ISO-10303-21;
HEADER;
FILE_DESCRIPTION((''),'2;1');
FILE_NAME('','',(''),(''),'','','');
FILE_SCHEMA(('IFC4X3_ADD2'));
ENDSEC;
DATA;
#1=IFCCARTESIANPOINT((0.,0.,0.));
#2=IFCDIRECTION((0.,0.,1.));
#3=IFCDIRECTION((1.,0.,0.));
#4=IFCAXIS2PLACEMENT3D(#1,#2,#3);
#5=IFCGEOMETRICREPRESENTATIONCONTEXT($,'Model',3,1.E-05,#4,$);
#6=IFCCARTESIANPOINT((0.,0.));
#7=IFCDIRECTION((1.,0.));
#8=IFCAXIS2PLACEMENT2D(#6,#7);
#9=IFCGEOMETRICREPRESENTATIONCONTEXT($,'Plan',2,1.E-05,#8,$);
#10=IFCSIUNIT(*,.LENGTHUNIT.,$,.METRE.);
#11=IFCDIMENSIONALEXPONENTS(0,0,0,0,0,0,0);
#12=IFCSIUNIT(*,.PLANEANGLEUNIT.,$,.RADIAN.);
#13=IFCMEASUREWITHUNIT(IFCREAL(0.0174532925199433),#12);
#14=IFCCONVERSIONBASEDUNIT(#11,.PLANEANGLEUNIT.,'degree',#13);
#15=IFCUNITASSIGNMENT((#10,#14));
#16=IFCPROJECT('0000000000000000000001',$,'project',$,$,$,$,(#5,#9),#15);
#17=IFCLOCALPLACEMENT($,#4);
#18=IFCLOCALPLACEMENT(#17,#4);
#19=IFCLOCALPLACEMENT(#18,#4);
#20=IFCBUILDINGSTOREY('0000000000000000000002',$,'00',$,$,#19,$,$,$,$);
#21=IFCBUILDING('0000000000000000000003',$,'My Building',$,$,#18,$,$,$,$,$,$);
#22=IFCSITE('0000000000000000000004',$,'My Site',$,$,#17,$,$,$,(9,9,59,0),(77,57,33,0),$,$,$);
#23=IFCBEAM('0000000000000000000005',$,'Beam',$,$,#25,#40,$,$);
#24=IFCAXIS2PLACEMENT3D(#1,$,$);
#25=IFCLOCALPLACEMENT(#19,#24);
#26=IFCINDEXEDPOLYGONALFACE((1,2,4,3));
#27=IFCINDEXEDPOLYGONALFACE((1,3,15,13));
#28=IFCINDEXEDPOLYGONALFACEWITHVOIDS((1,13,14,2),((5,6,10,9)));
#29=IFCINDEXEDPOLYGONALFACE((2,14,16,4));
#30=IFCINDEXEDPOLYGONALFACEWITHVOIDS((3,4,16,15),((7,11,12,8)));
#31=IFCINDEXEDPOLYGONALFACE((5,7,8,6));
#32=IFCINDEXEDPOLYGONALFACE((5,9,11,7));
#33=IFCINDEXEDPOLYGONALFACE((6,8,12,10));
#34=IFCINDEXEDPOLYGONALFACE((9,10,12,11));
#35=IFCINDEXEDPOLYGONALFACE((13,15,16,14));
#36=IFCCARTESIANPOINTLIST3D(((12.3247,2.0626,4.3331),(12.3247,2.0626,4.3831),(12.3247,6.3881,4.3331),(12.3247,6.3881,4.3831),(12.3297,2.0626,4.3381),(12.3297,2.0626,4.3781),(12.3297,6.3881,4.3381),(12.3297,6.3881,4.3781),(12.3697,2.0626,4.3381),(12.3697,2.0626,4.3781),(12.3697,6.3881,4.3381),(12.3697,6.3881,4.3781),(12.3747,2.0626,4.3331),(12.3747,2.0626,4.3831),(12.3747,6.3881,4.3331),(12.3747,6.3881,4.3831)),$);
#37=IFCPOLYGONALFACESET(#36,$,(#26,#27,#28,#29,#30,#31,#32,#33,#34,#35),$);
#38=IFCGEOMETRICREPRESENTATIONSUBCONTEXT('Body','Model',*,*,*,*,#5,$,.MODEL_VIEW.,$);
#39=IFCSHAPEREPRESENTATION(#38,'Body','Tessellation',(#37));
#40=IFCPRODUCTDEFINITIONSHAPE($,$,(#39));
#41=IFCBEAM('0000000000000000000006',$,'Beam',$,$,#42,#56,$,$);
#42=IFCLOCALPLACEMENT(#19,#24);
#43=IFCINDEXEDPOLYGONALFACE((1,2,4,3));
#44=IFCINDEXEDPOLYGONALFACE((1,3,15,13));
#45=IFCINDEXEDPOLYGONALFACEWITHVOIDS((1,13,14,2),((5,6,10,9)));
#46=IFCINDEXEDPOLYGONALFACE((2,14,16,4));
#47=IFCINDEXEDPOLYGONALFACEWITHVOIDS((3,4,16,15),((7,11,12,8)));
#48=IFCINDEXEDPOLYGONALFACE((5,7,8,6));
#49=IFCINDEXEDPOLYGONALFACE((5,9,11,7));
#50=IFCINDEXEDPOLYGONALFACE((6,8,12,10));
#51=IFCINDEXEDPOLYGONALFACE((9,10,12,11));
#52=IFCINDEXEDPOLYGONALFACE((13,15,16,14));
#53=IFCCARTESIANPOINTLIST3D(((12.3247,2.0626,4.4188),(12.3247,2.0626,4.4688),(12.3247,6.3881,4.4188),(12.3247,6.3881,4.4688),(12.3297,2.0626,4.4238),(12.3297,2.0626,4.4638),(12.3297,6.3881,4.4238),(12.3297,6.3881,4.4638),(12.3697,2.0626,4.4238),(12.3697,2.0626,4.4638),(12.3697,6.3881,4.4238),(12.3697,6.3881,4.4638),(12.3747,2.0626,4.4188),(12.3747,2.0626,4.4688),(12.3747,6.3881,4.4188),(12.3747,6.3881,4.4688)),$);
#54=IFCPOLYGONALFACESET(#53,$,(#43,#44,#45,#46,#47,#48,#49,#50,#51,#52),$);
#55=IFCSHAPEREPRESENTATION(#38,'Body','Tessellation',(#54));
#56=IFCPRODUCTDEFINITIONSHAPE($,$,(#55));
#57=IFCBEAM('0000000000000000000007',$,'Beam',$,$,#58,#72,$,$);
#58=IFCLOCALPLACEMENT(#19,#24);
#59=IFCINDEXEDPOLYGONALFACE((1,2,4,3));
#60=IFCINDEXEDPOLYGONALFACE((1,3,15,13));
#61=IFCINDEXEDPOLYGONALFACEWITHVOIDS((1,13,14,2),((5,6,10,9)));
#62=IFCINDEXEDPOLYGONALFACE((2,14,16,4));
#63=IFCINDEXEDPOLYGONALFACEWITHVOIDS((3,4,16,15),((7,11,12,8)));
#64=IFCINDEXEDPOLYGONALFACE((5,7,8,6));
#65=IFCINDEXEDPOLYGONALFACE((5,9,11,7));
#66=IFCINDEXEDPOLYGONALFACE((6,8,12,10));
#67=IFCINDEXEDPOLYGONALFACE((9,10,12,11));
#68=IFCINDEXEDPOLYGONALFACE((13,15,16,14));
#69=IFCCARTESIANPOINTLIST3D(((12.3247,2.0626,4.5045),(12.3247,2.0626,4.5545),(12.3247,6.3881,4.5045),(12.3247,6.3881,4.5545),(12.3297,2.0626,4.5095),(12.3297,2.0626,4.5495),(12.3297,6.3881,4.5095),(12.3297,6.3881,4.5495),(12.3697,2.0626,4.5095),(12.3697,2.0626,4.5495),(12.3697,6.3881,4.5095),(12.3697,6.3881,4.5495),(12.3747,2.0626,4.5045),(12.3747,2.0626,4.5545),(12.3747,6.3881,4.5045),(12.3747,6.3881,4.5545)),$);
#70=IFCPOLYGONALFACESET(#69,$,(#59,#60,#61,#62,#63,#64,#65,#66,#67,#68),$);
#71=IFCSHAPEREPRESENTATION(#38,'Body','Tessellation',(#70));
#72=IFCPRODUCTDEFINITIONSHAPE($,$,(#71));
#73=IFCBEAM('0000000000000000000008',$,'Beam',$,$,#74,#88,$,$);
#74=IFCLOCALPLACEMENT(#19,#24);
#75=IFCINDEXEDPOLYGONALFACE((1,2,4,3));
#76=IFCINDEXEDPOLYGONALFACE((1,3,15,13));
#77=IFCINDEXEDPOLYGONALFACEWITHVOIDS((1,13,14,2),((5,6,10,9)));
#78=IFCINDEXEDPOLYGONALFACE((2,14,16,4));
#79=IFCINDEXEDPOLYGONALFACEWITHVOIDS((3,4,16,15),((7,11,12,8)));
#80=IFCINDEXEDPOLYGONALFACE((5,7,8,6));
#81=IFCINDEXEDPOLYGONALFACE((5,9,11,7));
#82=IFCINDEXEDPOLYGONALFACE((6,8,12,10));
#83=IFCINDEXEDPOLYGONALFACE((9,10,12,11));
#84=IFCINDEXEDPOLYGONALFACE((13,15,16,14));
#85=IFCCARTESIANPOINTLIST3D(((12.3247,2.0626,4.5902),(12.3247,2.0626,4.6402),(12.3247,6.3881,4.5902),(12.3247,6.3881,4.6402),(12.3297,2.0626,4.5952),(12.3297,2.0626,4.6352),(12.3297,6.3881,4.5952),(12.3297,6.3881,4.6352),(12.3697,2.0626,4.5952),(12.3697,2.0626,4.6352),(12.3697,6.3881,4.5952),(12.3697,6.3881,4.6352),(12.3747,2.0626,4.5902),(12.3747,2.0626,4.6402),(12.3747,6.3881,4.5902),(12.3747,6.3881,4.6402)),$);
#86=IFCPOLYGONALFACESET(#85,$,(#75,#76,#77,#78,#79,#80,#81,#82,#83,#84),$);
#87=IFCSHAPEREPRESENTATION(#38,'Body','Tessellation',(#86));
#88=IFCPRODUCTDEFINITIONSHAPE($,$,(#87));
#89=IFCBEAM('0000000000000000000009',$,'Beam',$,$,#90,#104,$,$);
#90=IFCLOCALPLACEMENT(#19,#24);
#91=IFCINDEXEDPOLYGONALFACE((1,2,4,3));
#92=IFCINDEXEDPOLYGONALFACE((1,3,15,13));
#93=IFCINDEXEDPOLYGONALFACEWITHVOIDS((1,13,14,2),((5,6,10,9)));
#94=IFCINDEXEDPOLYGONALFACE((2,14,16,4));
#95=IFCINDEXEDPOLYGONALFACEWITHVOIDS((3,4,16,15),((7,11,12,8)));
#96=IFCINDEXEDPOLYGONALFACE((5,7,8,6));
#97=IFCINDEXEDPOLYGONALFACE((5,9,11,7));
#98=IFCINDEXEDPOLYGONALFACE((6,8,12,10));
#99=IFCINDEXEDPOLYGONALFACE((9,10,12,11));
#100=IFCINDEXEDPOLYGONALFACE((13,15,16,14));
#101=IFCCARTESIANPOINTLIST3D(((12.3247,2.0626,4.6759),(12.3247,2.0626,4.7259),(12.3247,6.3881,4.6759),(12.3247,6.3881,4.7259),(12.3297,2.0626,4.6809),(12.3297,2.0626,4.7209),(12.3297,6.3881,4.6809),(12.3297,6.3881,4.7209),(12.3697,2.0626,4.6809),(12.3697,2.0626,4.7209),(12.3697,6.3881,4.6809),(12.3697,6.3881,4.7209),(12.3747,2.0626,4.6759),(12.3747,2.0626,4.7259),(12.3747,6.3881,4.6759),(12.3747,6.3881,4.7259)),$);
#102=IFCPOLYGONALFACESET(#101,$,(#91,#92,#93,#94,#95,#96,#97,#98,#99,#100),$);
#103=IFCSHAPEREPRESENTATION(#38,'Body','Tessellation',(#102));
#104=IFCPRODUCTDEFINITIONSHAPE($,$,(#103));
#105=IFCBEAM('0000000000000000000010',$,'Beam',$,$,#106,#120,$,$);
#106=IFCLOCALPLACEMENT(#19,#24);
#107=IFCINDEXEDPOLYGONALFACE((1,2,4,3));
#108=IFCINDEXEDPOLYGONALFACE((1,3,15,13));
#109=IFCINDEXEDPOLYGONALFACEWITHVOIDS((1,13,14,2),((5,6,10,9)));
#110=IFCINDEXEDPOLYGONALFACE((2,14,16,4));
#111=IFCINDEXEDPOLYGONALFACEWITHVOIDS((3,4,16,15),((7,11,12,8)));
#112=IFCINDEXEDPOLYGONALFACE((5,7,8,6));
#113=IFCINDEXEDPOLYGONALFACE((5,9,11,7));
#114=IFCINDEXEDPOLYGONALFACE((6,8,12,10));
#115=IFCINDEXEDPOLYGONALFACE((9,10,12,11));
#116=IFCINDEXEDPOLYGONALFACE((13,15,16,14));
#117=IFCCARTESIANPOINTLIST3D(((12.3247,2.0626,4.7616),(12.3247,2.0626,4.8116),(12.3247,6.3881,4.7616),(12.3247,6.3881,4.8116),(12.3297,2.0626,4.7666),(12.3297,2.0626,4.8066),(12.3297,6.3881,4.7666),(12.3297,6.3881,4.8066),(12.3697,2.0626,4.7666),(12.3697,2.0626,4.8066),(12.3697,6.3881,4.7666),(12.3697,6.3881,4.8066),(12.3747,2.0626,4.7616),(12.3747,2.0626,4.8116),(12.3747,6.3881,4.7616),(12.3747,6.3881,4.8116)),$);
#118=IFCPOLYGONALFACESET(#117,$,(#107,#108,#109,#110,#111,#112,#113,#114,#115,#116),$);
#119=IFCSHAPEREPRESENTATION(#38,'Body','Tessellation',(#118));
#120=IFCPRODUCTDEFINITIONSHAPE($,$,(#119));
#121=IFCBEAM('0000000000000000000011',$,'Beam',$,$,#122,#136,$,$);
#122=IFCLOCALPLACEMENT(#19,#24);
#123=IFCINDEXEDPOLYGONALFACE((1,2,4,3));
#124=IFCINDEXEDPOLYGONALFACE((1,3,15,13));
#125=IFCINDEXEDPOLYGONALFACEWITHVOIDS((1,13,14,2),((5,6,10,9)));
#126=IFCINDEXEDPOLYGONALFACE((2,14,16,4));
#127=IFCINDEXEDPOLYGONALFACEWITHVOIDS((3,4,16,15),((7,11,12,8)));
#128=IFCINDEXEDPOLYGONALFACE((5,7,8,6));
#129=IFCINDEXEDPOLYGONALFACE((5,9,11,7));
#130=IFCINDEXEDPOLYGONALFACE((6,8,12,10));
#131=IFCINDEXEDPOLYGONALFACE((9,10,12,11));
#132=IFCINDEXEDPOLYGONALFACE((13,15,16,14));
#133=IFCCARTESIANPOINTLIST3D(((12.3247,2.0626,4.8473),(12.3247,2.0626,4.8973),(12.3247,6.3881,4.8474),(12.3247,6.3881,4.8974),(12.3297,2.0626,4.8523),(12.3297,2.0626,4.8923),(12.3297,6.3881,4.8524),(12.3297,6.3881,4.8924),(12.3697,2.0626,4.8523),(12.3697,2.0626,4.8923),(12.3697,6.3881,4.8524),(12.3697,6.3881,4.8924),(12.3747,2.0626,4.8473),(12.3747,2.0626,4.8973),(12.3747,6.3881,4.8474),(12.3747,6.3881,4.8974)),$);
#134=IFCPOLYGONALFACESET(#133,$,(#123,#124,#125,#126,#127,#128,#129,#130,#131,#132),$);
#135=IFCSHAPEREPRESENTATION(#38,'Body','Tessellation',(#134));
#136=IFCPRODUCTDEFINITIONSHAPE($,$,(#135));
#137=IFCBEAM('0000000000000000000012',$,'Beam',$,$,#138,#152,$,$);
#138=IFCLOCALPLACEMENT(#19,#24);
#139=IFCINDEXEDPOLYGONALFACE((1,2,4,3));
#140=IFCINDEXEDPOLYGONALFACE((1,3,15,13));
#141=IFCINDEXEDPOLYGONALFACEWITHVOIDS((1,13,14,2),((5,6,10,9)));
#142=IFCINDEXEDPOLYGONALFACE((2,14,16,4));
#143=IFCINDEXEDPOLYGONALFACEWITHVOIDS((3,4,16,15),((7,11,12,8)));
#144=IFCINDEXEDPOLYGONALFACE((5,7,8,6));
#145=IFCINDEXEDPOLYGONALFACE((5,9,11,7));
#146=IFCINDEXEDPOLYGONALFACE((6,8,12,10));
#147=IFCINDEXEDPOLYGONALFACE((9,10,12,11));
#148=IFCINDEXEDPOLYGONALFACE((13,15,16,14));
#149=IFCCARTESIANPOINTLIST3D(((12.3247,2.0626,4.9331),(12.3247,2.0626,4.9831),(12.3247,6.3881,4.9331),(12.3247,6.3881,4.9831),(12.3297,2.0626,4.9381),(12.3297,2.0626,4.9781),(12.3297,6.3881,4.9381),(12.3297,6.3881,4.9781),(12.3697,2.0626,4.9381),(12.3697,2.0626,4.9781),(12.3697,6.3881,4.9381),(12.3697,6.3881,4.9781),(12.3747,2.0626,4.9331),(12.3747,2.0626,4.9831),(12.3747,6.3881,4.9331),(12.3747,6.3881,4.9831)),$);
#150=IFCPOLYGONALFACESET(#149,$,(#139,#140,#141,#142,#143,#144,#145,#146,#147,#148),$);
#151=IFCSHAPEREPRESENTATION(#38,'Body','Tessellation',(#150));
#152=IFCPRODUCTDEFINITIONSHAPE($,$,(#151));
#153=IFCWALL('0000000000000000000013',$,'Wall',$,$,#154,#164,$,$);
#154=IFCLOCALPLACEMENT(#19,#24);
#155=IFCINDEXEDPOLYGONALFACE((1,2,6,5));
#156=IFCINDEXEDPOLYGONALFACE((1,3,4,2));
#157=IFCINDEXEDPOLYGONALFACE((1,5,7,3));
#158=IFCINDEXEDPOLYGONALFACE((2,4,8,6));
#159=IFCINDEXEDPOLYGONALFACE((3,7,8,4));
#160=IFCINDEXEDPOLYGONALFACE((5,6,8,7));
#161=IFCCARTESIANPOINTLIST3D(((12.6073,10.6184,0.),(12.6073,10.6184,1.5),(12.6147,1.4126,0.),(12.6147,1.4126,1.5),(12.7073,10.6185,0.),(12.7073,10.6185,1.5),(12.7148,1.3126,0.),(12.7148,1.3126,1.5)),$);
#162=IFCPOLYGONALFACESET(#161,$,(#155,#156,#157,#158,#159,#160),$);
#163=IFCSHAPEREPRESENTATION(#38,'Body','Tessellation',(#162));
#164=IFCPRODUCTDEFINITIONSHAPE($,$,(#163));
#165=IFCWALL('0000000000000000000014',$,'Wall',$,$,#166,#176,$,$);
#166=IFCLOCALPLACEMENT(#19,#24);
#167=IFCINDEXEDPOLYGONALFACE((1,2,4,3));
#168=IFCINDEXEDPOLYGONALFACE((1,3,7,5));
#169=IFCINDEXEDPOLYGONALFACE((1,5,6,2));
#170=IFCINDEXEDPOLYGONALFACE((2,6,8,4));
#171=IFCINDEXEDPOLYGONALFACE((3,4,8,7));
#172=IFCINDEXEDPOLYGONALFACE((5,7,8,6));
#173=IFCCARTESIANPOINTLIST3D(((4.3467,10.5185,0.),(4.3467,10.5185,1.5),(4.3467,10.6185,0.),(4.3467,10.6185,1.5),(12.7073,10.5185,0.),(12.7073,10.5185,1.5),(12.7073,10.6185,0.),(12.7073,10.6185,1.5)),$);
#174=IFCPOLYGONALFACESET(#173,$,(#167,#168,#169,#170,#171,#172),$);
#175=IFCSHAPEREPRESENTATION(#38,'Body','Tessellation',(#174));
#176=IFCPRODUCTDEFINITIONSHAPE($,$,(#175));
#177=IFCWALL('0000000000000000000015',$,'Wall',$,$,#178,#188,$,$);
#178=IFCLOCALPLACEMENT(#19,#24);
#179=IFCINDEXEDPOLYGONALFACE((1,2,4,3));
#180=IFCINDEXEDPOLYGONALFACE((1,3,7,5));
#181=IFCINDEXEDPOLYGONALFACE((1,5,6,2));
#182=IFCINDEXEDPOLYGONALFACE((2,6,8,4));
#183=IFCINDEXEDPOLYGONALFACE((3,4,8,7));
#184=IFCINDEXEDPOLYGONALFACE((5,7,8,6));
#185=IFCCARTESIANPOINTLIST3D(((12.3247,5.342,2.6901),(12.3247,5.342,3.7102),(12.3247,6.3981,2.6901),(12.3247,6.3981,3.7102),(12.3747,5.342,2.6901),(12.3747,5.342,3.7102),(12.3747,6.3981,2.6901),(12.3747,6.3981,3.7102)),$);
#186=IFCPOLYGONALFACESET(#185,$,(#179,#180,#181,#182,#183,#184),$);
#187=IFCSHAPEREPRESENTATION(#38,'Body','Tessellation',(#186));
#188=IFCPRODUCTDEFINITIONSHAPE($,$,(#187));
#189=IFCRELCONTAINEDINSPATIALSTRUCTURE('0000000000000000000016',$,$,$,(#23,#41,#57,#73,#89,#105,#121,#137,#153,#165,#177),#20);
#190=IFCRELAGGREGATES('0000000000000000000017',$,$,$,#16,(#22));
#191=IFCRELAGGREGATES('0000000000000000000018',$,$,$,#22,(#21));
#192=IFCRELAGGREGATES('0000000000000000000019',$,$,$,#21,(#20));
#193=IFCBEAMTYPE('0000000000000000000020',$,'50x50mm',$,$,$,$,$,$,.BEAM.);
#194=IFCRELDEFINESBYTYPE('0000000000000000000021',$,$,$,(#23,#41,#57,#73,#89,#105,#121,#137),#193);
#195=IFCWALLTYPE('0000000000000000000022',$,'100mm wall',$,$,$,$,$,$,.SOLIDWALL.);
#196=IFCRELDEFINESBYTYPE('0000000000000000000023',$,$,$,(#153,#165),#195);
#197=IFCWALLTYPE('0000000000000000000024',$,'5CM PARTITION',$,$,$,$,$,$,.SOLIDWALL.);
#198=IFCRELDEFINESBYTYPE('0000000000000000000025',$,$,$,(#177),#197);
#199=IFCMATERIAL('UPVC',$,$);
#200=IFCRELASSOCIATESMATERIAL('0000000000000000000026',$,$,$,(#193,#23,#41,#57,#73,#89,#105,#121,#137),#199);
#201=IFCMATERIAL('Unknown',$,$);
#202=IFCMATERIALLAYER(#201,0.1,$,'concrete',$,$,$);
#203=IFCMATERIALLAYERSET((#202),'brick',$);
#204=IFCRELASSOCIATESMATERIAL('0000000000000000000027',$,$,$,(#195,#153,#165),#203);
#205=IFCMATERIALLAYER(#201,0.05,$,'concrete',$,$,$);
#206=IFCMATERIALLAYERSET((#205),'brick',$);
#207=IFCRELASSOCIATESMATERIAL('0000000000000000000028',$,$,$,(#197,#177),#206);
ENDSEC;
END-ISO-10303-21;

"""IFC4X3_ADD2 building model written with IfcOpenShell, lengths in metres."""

from ifc_helpers import new_model, entity, si_unit, converted_unit, frame, origin_with_axes, origin_2d_with_axis, place, context, subcontext, project, spatial, line, indexed_curve, hollow_rectangle, outline, extrude, material, layer, layer_set, layer_usage, material_profile, profile_set, profile_usage, type_object, element, save


model = new_model("IFC4X3_ADD2")

# Units and contexts
model_context = context("Model", 3, precision=1e-05, world=origin_with_axes())
plan_context = context("Plan", 2, precision=1e-05, world=origin_2d_with_axis())
body_context = subcontext(model_context, "Body", "Model", "MODEL_VIEW")
ifc_project = project(units=[si_unit("LENGTHUNIT", "METRE"), converted_unit("PLANEANGLEUNIT", "degree", entity("IfcReal", 0.0174532925199433), si_unit("PLANEANGLEUNIT", "RADIAN"), dimensions=[0, 0, 0, 0, 0, 0, 0])], contexts=[model_context, plan_context])

# Site, building, storey
site_placement = place(None, origin_with_axes())
site = spatial("IfcSite", under=ifc_project, at=site_placement, Name="My Site", RefLatitude=(9, 9, 59, 0), RefLongitude=(77, 57, 33, 0))
building_placement = place(site_placement, origin_with_axes())
building = spatial("IfcBuilding", under=site, at=building_placement, Name="My Building")
storey_placement = place(building_placement, origin_with_axes())
storey = spatial("IfcBuildingStorey", under=building, at=storey_placement, Name="00")

# Shared definitions
ifc_material_1 = material(Name="UPVC")

# Beams
ifc_material_profile_1 = material_profile(ifc_material_1, hollow_rectangle(XDim=0.05, YDim=0.05, WallThickness=0.005))
ifc_profile_set_1 = profile_set([ifc_material_profile_1])
beam_type = type_object("IfcBeamType", Name="50x50mm", PredefinedType="BEAM", material=ifc_profile_set_1)
ifc_profile_usage_1 = profile_usage(ifc_profile_set_1, cardinal=5)
beam_1_placement = place(storey_placement, frame((12.3497, 2.0626, 4.3581), z_axis=(0.0, 1.0, 0.000001), x_axis=(-1.0, 0.0, 0.0)))
element("IfcBeam", 1, at=beam_1_placement, inside=storey, type_object=beam_type, material=ifc_profile_usage_1, Name="Beam", context=body_context, shape_type="SweptSolid", body=[
    extrude(hollow_rectangle(XDim=0.05, YDim=0.05, WallThickness=0.005), origin_with_axes(), (0.0, 0.0, 1.0), 4.3255),
])
ifc_profile_usage_2 = profile_usage(ifc_profile_set_1, cardinal=5)
beam_2_placement = place(storey_placement, frame((12.3497, 2.0626, 4.4438), z_axis=(0.0, 1.0, 0.000001), x_axis=(-1.0, 0.0, 0.0)))
element("IfcBeam", 2, at=beam_2_placement, inside=storey, type_object=beam_type, material=ifc_profile_usage_2, Name="Beam", context=body_context, shape_type="SweptSolid", body=[
    extrude(hollow_rectangle(XDim=0.05, YDim=0.05, WallThickness=0.005), origin_with_axes(), (0.0, 0.0, 1.0), 4.3255),
])
ifc_profile_usage_3 = profile_usage(ifc_profile_set_1, cardinal=5)
beam_3_placement = place(storey_placement, frame((12.3497, 2.0626, 4.5295), z_axis=(0.0, 1.0, 0.000001), x_axis=(-1.0, 0.0, 0.0)))
element("IfcBeam", 3, at=beam_3_placement, inside=storey, type_object=beam_type, material=ifc_profile_usage_3, Name="Beam", context=body_context, shape_type="SweptSolid", body=[
    extrude(hollow_rectangle(XDim=0.05, YDim=0.05, WallThickness=0.005), origin_with_axes(), (0.0, 0.0, 1.0), 4.3255),
])
ifc_profile_usage_4 = profile_usage(ifc_profile_set_1, cardinal=5)
beam_4_placement = place(storey_placement, frame((12.3497, 2.0626, 4.6152), z_axis=(0.0, 1.0, 0.000001), x_axis=(-1.0, 0.0, 0.0)))
element("IfcBeam", 4, at=beam_4_placement, inside=storey, type_object=beam_type, material=ifc_profile_usage_4, Name="Beam", context=body_context, shape_type="SweptSolid", body=[
    extrude(hollow_rectangle(XDim=0.05, YDim=0.05, WallThickness=0.005), origin_with_axes(), (0.0, 0.0, 1.0), 4.3255),
])
ifc_profile_usage_5 = profile_usage(ifc_profile_set_1, cardinal=5)
beam_5_placement = place(storey_placement, frame((12.3497, 2.0626, 4.7009), z_axis=(0.0, 1.0, 0.000001), x_axis=(-1.0, 0.0, 0.0)))
element("IfcBeam", 5, at=beam_5_placement, inside=storey, type_object=beam_type, material=ifc_profile_usage_5, Name="Beam", context=body_context, shape_type="SweptSolid", body=[
    extrude(hollow_rectangle(XDim=0.05, YDim=0.05, WallThickness=0.005), origin_with_axes(), (0.0, 0.0, 1.0), 4.3255),
])
ifc_profile_usage_6 = profile_usage(ifc_profile_set_1, cardinal=5)
beam_6_placement = place(storey_placement, frame((12.3497, 2.0626, 4.7866), z_axis=(0.0, 1.0, 0.000001), x_axis=(-1.0, 0.0, 0.0)))
element("IfcBeam", 6, at=beam_6_placement, inside=storey, type_object=beam_type, material=ifc_profile_usage_6, Name="Beam", context=body_context, shape_type="SweptSolid", body=[
    extrude(hollow_rectangle(XDim=0.05, YDim=0.05, WallThickness=0.005), origin_with_axes(), (0.0, 0.0, 1.0), 4.3255),
])
ifc_profile_usage_7 = profile_usage(ifc_profile_set_1, cardinal=5)
beam_7_placement = place(storey_placement, frame((12.3497, 2.0626, 4.8723), z_axis=(0.0, 1.0, 0.000001), x_axis=(-1.0, 0.0, 0.0)))
element("IfcBeam", 7, at=beam_7_placement, inside=storey, type_object=beam_type, material=ifc_profile_usage_7, Name="Beam", context=body_context, shape_type="SweptSolid", body=[
    extrude(hollow_rectangle(XDim=0.05, YDim=0.05, WallThickness=0.005), origin_with_axes(), (0.0, 0.0, 1.0), 4.3255),
])
ifc_profile_usage_8 = profile_usage(ifc_profile_set_1, cardinal=5)
beam_8_placement = place(storey_placement, frame((12.3497, 2.0626, 4.9581), z_axis=(0.0, 1.0, 0.000001), x_axis=(-1.0, 0.0, 0.0)))
element("IfcBeam", 8, at=beam_8_placement, inside=storey, type_object=beam_type, material=ifc_profile_usage_8, Name="Beam", context=body_context, shape_type="SweptSolid", body=[
    extrude(hollow_rectangle(XDim=0.05, YDim=0.05, WallThickness=0.005), origin_with_axes(), (0.0, 0.0, 1.0), 4.3255),
])

# Walls
ifc_material_2 = material(Name="Unknown")
ifc_layer_1 = layer(ifc_material_2, 0.1, Name="concrete")
ifc_layer_set_1 = layer_set([ifc_layer_1], Name="brick")
ifc_layer_usage_1 = layer_usage(ifc_layer_set_1, "AXIS2", "POSITIVE", 0.0)
wall_type_1 = type_object("IfcWallType", Name="100mm wall", PredefinedType="SOLIDWALL", material=ifc_layer_set_1)
wall_1_placement = place(storey_placement, frame((12.7148, 1.3126, 0.0), z_axis=(0.0, 0.0, 1.0), x_axis=(-0.000805, 1.0, 0.0)))
element("IfcWall", 9, at=wall_1_placement, inside=storey, type_object=wall_type_1, material=ifc_layer_usage_1, Name="Wall", context=body_context, shape_type="SweptSolid", body=[
    extrude(outline(indexed_curve([(0.0, 0.0), (0.1001, 0.1), (9.3059, 0.1), (9.3059, 0.0)], segments=[line(1, 2, 3, 4, 1)])), origin_with_axes(), (0.0, 0.0, 1.0), 1.5),
])
ifc_layer_usage_2 = layer_usage(ifc_layer_set_1, "AXIS2", "POSITIVE", 0.0)
wall_2_placement = place(storey_placement, frame((12.7073, 10.6185, 0.0), z_axis=(0.0, 0.0, 1.0), x_axis=(-1.0, 0.0, 0.0)))
element("IfcWall", 10, at=wall_2_placement, inside=storey, type_object=wall_type_1, material=ifc_layer_usage_2, Name="Wall", context=body_context, shape_type="SweptSolid", body=[
    extrude(outline(indexed_curve([(0.0, 0.0), (0.0, 0.1), (8.3606, 0.1), (8.3606, 0.0)], segments=[line(1, 2, 3, 4, 1)])), origin_with_axes(), (0.0, 0.0, 1.0), 1.5),
])
ifc_layer_2 = layer(ifc_material_2, 0.05, Name="concrete")
ifc_layer_set_2 = layer_set([ifc_layer_2], Name="brick")
ifc_layer_usage_3 = layer_usage(ifc_layer_set_2, "AXIS2", "POSITIVE", 0.0)
wall_type_2 = type_object("IfcWallType", Name="5CM PARTITION", PredefinedType="SOLIDWALL", material=ifc_layer_set_2)
wall_3_placement = place(storey_placement, frame((12.3247, 6.3981, 2.6901), z_axis=(0.0, 0.0, 1.0), x_axis=(0.0, -1.0, 0.0)))
element("IfcWall", 11, at=wall_3_placement, inside=storey, type_object=wall_type_2, material=ifc_layer_usage_3, Name="Wall", context=body_context, shape_type="SweptSolid", body=[
    extrude(outline(indexed_curve([(0.0, 0.0), (0.0, 0.05), (1.0561, 0.05), (1.0561, 0.0)], segments=[line(1, 2, 3, 4, 1)])), origin_with_axes(), (0.0, 0.0, 1.0), 1.0201),
])

save(model, "model.ifc")
